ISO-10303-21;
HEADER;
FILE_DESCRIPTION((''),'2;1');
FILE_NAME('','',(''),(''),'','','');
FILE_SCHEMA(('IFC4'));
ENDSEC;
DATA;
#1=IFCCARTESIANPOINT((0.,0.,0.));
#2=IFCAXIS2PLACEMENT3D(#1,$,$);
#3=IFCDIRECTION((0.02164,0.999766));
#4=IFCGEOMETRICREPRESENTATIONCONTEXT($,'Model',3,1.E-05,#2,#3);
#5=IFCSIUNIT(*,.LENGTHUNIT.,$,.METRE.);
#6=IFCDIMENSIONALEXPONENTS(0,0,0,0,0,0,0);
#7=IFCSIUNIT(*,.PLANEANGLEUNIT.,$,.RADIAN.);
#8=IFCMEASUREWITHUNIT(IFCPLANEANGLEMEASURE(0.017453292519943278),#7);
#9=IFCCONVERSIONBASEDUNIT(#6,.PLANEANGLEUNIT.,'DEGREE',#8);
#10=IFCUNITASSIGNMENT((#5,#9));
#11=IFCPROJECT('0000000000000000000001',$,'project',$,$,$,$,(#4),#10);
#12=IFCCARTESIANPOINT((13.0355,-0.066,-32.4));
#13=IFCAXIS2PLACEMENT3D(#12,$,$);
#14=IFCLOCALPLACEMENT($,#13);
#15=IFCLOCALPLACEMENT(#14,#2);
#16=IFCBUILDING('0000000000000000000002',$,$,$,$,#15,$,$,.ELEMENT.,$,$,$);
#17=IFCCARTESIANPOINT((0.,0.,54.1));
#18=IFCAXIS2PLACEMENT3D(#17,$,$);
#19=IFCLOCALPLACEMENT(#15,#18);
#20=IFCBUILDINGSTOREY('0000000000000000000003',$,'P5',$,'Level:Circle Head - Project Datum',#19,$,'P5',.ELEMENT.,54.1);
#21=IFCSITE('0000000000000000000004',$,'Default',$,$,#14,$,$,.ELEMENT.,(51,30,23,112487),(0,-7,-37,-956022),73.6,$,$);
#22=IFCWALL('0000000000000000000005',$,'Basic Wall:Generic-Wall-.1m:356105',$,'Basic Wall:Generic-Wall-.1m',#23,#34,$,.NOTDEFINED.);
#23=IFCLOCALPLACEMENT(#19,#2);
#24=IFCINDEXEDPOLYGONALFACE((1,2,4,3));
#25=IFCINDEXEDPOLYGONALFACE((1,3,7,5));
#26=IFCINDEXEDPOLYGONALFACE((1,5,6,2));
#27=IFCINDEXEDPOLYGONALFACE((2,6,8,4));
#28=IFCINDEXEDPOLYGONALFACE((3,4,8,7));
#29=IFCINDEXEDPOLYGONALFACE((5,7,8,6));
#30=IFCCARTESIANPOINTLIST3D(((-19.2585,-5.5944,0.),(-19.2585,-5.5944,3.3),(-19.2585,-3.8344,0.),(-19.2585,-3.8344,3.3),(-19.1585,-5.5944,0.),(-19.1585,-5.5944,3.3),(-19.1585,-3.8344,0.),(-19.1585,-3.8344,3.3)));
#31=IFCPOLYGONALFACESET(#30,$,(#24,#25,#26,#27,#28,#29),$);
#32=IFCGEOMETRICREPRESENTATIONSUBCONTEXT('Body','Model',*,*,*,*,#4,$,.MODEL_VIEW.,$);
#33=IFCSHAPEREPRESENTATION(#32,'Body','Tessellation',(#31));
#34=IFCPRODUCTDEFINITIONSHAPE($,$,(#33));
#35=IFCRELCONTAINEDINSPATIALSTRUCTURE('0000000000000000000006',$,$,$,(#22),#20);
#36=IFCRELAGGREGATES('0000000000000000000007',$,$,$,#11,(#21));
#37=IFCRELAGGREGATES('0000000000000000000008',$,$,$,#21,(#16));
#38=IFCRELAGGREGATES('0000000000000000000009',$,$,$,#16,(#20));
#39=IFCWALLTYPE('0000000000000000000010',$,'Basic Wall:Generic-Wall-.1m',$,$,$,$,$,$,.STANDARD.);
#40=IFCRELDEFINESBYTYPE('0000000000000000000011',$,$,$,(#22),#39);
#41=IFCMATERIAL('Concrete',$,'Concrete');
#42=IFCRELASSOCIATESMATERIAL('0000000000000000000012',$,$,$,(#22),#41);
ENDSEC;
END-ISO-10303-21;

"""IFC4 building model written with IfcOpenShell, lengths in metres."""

from ifc_helpers import new_model, entity, si_unit, converted_unit, direction, frame, origin, place, context, subcontext, project, spatial, indexed_curve, outline, extrude, material, type_object, element, save


model = new_model("IFC4")

# Units and contexts
model_context = context("Model", 3, precision=1e-05, world=origin(), true_north=direction((0.02164, 0.999766)))
body_context = subcontext(model_context, "Body", "Model", "MODEL_VIEW")
ifc_project = project(units=[si_unit("LENGTHUNIT", "METRE"), converted_unit("PLANEANGLEUNIT", "DEGREE", entity("IfcPlaneAngleMeasure", 0.017453292519943278), si_unit("PLANEANGLEUNIT", "RADIAN"), dimensions=[0, 0, 0, 0, 0, 0, 0])], contexts=[model_context])

# Site, building, storey
site_placement = place(None, frame((13.0355, -0.066, -32.4)))
site = spatial("IfcSite", under=ifc_project, at=site_placement, Name="Default", CompositionType="ELEMENT", RefLatitude=(51, 30, 23, 112487), RefLongitude=(0, -7, -37, -956022), RefElevation=73.6)
building_placement = place(site_placement, origin())
building = spatial("IfcBuilding", under=site, at=building_placement, CompositionType="ELEMENT")
storey_placement = place(building_placement, frame((0.0, 0.0, 54.1)))
storey = spatial("IfcBuildingStorey", under=building, at=storey_placement, Name="P5", ObjectType="Level:Circle Head - Project Datum", LongName="P5", CompositionType="ELEMENT", Elevation=54.1)

# Shared definitions
ifc_material = material(Name="Concrete", Category="Concrete")

# Wall
wall_type = type_object("IfcWallType", Name="Basic Wall:Generic-Wall-.1m", PredefinedType="STANDARD")
wall_1_placement = place(storey_placement, frame((-19.2085, -5.5944, 0.0), z_axis=(0.0, 0.0, 1.0), x_axis=(0.0, 1.0, 0.0)))
element("IfcWall", 1, at=wall_1_placement, inside=storey, type_object=wall_type, material=ifc_material, Name="Basic Wall:Generic-Wall-.1m:356105", ObjectType="Basic Wall:Generic-Wall-.1m", PredefinedType="NOTDEFINED", context=body_context, shape_type="SweptSolid", body=[
    extrude(outline(indexed_curve([(1.76, -0.05), (1.76, 0.05), (0.0, 0.05), (0.0, -0.05), (1.76, -0.05)], self_intersect=False)), origin(), (0.0, 0.0, 1.0), 3.3),
])

save(model, "model.ifc")
